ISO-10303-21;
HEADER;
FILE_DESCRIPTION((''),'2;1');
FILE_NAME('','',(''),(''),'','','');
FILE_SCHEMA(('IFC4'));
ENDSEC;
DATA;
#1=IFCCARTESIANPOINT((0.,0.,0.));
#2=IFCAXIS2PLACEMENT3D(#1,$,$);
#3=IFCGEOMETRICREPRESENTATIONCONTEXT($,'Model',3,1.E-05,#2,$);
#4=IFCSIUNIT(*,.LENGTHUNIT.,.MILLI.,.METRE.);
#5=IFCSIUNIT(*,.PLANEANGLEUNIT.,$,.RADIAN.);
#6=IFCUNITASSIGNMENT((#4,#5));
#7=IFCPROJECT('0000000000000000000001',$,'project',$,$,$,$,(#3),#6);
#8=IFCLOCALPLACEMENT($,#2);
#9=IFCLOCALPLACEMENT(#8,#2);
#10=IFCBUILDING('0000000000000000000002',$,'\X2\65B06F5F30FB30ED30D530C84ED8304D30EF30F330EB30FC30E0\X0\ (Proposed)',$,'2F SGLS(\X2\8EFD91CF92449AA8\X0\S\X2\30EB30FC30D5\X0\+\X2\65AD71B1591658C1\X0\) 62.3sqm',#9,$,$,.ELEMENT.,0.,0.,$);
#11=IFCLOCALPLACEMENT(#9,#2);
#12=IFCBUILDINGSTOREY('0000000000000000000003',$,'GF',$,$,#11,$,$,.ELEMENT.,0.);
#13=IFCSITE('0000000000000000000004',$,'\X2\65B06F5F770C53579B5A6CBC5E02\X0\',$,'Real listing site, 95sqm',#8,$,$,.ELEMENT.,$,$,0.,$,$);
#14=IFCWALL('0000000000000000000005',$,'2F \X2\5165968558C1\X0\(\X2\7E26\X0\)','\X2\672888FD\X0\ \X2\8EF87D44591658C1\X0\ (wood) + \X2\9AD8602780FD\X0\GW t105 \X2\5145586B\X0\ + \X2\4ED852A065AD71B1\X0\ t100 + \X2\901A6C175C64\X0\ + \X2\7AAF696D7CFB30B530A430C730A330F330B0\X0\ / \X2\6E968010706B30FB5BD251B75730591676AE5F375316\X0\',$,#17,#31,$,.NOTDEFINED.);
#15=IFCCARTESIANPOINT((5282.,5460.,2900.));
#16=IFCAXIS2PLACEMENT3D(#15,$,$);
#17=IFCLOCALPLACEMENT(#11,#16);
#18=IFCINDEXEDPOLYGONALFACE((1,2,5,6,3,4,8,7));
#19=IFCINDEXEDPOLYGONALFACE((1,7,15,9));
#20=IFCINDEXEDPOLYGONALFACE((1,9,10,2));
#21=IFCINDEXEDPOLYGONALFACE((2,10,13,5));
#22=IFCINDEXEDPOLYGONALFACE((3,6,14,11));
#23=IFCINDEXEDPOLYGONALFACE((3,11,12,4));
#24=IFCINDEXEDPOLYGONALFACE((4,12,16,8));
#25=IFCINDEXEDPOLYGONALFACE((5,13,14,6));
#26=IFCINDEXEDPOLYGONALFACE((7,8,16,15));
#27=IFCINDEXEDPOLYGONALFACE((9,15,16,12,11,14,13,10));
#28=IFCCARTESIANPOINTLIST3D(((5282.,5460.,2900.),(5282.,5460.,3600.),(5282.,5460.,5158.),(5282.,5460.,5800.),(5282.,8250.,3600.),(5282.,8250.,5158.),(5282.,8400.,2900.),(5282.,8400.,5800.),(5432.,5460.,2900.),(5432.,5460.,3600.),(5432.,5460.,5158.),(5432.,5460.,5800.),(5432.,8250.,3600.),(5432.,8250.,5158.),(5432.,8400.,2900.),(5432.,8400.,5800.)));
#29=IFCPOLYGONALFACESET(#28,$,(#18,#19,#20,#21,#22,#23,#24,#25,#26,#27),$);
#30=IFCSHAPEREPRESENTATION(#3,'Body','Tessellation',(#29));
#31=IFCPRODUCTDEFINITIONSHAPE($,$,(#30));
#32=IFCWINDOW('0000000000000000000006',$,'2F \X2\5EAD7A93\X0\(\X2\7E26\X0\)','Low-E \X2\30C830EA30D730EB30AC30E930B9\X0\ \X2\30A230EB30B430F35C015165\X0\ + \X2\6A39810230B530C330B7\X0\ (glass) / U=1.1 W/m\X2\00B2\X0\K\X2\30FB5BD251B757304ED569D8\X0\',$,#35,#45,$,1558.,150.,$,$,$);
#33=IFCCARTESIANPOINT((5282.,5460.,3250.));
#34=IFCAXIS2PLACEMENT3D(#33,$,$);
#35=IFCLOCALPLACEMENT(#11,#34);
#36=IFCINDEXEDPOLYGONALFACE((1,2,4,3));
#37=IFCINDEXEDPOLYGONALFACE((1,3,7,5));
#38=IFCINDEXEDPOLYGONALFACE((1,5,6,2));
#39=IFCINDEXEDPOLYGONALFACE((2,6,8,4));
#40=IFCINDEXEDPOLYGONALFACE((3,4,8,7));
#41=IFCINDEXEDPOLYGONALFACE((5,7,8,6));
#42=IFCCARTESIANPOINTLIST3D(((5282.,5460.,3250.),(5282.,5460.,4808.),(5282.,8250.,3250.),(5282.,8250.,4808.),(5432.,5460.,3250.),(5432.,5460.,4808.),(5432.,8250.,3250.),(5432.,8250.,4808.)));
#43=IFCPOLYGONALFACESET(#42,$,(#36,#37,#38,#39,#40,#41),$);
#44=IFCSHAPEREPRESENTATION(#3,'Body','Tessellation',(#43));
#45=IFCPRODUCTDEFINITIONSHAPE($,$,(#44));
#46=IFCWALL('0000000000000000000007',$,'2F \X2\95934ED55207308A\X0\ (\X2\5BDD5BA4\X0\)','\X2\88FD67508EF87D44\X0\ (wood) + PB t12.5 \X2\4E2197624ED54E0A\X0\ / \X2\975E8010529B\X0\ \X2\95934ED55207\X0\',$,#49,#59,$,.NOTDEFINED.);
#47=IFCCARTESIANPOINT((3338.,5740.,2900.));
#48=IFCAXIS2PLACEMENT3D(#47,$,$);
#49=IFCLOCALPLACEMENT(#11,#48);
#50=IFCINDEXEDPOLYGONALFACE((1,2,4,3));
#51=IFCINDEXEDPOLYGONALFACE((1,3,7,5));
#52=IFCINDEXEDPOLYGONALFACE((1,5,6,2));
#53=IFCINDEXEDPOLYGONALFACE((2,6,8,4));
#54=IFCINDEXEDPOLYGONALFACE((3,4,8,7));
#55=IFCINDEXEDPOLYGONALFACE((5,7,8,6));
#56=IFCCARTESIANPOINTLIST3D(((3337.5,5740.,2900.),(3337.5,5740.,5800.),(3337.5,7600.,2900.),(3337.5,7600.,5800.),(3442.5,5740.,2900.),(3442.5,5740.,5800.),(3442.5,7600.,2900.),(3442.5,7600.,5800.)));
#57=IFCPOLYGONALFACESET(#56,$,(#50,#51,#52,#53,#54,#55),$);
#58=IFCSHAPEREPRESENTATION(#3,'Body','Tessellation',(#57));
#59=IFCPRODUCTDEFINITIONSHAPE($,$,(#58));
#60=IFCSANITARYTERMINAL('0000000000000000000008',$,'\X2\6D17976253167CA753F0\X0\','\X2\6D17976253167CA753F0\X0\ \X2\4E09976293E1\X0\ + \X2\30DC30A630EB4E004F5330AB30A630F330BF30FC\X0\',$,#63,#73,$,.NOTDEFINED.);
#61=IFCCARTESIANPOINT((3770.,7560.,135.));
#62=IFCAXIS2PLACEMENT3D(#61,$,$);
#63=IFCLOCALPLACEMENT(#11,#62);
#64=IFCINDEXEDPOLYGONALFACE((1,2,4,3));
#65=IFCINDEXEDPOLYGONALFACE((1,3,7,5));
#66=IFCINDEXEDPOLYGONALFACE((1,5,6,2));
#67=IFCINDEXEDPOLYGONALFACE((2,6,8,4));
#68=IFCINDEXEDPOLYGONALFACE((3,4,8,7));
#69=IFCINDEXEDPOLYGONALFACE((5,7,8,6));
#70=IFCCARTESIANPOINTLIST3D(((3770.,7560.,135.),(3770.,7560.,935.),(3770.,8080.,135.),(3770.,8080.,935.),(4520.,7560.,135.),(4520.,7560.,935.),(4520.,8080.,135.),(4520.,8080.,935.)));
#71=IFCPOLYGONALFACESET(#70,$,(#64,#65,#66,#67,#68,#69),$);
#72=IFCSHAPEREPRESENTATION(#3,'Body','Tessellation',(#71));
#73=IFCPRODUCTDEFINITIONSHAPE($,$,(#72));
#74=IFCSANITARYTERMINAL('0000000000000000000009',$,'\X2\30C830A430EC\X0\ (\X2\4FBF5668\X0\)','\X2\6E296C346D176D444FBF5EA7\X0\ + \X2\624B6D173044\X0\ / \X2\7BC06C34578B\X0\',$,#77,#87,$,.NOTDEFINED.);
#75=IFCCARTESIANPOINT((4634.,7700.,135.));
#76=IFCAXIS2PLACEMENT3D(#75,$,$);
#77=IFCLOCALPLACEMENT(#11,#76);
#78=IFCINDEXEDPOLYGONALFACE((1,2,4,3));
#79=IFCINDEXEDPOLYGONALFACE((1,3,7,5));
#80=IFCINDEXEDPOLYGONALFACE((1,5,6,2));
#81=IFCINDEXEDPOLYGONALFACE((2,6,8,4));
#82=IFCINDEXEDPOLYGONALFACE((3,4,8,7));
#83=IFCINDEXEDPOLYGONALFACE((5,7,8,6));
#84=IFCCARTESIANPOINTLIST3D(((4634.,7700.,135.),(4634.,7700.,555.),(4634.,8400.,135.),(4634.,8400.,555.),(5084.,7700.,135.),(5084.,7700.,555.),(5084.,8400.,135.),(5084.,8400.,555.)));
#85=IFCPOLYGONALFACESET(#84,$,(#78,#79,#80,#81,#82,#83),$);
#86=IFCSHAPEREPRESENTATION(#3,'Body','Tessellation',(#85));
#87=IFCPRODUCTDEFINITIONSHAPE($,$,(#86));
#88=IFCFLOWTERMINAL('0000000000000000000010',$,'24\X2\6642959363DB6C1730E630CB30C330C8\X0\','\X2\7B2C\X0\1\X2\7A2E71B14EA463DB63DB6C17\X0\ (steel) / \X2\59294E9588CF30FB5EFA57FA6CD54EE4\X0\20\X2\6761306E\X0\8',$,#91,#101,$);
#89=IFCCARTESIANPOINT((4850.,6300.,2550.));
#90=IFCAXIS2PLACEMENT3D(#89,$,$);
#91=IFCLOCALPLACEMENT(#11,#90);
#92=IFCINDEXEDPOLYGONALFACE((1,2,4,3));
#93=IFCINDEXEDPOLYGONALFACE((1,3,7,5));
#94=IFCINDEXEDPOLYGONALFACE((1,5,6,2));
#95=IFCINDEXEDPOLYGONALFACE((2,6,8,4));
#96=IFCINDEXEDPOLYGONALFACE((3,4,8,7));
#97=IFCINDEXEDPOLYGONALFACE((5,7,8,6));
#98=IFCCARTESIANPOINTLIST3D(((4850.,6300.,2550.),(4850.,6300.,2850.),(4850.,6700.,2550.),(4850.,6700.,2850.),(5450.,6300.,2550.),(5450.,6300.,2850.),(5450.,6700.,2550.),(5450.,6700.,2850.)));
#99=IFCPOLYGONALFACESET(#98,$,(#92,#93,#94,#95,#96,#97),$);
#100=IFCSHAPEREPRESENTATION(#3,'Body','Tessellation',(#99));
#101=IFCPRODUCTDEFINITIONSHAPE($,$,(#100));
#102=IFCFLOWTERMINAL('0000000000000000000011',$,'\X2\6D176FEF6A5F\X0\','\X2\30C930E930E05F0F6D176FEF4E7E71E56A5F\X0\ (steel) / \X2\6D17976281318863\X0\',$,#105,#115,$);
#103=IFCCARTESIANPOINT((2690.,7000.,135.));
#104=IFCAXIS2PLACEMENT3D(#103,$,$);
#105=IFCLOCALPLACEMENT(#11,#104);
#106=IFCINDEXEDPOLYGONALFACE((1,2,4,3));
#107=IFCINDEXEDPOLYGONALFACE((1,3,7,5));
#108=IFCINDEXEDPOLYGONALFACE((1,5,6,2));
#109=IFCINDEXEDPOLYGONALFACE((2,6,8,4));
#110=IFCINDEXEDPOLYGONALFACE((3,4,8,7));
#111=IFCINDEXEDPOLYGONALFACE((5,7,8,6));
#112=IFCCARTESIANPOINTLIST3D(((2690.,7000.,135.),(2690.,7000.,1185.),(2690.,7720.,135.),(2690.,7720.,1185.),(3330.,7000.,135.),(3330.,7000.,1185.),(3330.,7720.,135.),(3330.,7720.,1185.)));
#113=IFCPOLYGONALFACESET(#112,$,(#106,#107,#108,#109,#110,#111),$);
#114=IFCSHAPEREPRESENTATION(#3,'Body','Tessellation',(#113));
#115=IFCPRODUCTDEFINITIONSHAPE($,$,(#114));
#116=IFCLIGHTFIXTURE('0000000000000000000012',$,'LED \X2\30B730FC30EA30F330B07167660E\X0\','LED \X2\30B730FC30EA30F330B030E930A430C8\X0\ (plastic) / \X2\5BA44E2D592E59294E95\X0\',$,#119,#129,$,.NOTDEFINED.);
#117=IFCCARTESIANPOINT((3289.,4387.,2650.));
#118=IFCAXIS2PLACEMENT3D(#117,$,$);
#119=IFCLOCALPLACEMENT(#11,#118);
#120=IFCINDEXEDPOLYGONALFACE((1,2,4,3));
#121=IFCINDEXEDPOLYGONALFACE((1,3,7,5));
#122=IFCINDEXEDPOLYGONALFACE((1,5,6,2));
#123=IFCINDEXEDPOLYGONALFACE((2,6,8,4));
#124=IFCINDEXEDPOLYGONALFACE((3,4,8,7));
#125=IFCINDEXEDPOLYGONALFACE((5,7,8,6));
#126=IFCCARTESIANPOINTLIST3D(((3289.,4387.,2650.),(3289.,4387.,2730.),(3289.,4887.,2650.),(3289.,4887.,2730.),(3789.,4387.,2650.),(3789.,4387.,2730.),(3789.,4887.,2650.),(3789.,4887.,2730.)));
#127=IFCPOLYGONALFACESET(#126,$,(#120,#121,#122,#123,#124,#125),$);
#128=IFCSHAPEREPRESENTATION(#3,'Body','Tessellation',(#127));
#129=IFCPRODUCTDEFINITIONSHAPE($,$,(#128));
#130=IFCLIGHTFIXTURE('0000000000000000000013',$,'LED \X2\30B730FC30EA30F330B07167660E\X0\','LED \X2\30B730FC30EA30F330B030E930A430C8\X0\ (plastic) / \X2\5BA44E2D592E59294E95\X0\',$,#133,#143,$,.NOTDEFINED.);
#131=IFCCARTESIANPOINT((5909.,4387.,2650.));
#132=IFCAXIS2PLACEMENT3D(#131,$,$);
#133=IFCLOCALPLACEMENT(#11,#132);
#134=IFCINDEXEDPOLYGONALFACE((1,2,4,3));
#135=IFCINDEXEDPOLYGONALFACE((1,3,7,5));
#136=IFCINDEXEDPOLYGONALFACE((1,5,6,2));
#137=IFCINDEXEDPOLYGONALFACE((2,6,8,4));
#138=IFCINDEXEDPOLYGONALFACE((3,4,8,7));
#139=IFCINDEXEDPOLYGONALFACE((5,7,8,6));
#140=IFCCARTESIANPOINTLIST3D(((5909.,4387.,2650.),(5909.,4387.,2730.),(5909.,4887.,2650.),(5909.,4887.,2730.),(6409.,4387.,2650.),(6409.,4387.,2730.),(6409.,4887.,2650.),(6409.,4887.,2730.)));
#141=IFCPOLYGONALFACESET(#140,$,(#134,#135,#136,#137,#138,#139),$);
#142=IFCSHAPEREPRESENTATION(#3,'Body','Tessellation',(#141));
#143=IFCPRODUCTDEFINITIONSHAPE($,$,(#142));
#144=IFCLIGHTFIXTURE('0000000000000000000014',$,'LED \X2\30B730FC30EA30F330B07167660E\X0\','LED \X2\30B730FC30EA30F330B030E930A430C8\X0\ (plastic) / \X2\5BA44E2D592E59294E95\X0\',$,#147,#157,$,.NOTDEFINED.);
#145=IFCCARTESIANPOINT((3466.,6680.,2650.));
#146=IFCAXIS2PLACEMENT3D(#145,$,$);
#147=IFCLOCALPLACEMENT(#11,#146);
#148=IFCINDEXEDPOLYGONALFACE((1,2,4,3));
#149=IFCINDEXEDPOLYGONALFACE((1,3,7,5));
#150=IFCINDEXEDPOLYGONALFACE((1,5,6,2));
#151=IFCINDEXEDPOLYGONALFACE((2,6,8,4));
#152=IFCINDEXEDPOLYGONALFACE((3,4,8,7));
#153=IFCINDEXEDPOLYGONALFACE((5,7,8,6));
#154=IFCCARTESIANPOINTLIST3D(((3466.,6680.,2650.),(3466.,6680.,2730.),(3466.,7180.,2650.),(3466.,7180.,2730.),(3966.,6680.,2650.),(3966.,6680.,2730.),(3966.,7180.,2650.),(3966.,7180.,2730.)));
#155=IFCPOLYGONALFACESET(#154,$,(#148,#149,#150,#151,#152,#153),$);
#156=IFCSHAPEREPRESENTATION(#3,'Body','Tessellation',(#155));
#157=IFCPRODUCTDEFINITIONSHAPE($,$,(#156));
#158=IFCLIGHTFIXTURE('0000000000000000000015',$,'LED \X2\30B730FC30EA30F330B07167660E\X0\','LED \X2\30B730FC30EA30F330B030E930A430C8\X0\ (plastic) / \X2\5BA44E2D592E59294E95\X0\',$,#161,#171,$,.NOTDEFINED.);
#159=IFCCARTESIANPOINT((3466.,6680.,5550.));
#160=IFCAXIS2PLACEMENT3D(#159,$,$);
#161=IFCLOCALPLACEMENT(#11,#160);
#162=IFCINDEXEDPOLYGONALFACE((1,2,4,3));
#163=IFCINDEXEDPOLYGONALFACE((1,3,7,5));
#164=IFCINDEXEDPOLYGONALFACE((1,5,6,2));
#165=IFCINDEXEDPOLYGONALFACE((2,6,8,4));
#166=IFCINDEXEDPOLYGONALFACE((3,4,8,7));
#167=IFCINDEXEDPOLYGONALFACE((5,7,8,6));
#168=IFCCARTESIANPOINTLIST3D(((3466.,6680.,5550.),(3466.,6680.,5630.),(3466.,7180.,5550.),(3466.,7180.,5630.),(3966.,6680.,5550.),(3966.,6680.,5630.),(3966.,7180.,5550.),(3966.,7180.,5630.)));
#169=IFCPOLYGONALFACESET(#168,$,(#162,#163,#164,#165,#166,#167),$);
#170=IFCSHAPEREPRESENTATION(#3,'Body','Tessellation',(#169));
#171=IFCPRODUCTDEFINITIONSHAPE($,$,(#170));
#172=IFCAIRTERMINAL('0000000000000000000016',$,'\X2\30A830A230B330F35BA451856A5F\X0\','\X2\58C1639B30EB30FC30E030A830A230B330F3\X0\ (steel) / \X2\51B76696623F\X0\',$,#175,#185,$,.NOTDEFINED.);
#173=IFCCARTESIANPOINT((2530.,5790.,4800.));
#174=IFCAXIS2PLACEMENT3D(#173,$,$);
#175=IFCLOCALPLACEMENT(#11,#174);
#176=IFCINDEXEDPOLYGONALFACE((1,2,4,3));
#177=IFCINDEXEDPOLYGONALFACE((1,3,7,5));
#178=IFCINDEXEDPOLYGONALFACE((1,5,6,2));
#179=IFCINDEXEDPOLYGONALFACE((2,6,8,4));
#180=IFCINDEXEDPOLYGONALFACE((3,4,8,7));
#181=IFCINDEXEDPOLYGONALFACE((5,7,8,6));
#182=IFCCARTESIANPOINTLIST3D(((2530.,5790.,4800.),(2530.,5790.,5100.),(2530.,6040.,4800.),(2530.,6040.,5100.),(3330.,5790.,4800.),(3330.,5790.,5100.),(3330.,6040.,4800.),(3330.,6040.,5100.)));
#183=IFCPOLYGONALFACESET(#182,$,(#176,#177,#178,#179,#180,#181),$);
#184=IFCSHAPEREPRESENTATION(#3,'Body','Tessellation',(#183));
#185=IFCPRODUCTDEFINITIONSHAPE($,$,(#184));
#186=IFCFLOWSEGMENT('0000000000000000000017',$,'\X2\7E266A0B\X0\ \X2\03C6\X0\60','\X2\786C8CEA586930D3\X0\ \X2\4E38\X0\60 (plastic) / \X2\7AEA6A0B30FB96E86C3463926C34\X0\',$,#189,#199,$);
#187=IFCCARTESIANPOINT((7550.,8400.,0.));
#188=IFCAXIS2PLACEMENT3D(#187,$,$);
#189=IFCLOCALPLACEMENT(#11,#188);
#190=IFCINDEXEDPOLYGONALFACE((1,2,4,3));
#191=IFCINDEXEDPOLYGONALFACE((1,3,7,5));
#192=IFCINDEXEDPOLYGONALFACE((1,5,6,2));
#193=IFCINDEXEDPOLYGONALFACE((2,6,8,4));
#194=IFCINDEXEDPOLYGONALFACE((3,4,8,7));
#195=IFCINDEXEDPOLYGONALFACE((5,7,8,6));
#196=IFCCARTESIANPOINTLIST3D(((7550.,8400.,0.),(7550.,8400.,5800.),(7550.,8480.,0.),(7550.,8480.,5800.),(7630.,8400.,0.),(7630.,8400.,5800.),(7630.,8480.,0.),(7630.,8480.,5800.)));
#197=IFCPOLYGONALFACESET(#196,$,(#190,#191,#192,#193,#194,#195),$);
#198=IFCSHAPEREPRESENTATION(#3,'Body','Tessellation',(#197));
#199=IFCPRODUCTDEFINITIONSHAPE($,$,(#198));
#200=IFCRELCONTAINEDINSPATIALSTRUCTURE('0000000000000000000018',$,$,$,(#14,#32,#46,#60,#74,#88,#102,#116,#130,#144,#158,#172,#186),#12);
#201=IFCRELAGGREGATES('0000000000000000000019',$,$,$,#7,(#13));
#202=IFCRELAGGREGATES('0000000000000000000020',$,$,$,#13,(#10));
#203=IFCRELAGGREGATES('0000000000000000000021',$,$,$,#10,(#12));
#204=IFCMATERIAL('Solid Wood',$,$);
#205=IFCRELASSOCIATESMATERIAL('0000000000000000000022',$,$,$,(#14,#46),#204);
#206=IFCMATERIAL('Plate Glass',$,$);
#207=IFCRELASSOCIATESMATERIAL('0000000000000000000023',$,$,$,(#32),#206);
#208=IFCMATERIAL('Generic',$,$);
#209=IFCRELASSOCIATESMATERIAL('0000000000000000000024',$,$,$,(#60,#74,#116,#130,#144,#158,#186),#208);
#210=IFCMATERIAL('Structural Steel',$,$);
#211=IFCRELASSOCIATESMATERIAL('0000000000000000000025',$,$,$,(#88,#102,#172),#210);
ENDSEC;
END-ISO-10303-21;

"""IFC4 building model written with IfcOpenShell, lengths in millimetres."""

from ifc_helpers import new_model, si_unit, frame, frame_2d, origin, place, context, project, spatial, rectangle, extrude, material, element, fill, save


model = new_model("IFC4")

# Units and contexts
model_context = context("Model", 3, precision=1e-05, world=origin())
ifc_project = project(units=[si_unit("LENGTHUNIT", "METRE", prefix="MILLI"), si_unit("PLANEANGLEUNIT", "RADIAN")], contexts=[model_context])

# Site, building, storey
site_placement = place(None, origin())
site = spatial("IfcSite", under=ifc_project, at=site_placement, Name="新潟県南魚沼市", ObjectType="Real listing site, 95sqm", CompositionType="ELEMENT", RefElevation=0.0)
building_placement = place(site_placement, origin())
building = spatial("IfcBuilding", under=site, at=building_placement, Name="新潟・ロフト付きワンルーム (Proposed)", ObjectType="2F SGLS(軽量鉄骨Sルーフ+断熱外壁) 62.3sqm", CompositionType="ELEMENT", ElevationOfRefHeight=0.0, ElevationOfTerrain=0.0)
storey_placement = place(building_placement, origin())
storey = spatial("IfcBuildingStorey", under=building, at=storey_placement, Name="GF", CompositionType="ELEMENT", Elevation=0.0)

# Shared definitions
ifc_material_1 = material(Name="Solid Wood")

# Shared definitions
ifc_material_2 = material(Name="Plate Glass")

# Wall, opening, window
wall_1_placement = place(storey_placement, frame((5282.0, 5460.0, 2900.0)))
wall_1 = element("IfcWall", 1, at=wall_1_placement, inside=storey, material=ifc_material_1, Name="2F 入隅壁(縦)", Description="木製 軸組外壁 (wood) + 高性能GW t105 充填 + 付加断熱 t100 + 通気層 + 窯業系サイディング / 準耐火・寒冷地外皮強化", PredefinedType="NOTDEFINED", context=model_context, shape_type="SweptSolid", body=[
    extrude(rectangle(XDim=150.0, YDim=2940.0, at=frame_2d((75.0, 1470.0))), frame((5282.0, 5460.0, 2900.0)), (0.0, 0.0, 1.0), 2900.0),
])
opening_1_placement = place(storey_placement, frame((5282.0, 5460.0, 3250.0)))
opening_1 = element("IfcOpeningElement", 2, at=opening_1_placement, cuts=wall_1, PredefinedType="NOTDEFINED", context=model_context, shape_type="SweptSolid", body=[
    extrude(rectangle(XDim=150.0, YDim=2790.0, at=frame_2d((75.0, 1395.0))), frame((5282.0, 5460.0, 3250.0)), (0.0, 0.0, 1.0), 1558.0),
])
window_1_placement = place(storey_placement, frame((5282.0, 5460.0, 3250.0)))
window_1 = element("IfcWindow", 3, at=window_1_placement, inside=storey, material=ifc_material_2, Name="2F 庭窓(縦)", Description="Low-E トリプルガラス アルゴン封入 + 樹脂サッシ (glass) / U=1.1 W/m²K・寒冷地仕様", OverallHeight=1558.0, OverallWidth=150.0, context=model_context, shape_type="SweptSolid", body=[
    extrude(rectangle(XDim=150.0, YDim=2790.0, at=frame_2d((75.0, 1395.0))), frame((5282.0, 5460.0, 3250.0)), (0.0, 0.0, 1.0), 1558.0),
])
fill(opening_1, window_1)

# Wall
wall_2_placement = place(storey_placement, frame((3338.0, 5740.0, 2900.0)))
element("IfcWall", 4, at=wall_2_placement, inside=storey, material=ifc_material_1, Name="2F 間仕切り (寝室)", Description="製材軸組 (wood) + PB t12.5 両面仕上 / 非耐力 間仕切", PredefinedType="NOTDEFINED", context=model_context, shape_type="SweptSolid", body=[
    extrude(rectangle(XDim=105.0, YDim=1860.0, at=frame_2d((52.0, 930.0))), frame((3338.0, 5740.0, 2900.0)), (0.0, 0.0, 1.0), 2900.0),
])

# Sanitary terminals
ifc_material_3 = material(Name="Generic")
sanitary_terminal_1_placement = place(storey_placement, frame((3770.0, 7560.0, 135.0)))
element("IfcSanitaryTerminal", 5, at=sanitary_terminal_1_placement, inside=storey, material=ifc_material_3, Name="洗面化粧台", Description="洗面化粧台 三面鏡 + ボウル一体カウンター", PredefinedType="NOTDEFINED", context=model_context, shape_type="SweptSolid", body=[
    extrude(rectangle(XDim=750.0, YDim=520.0, at=frame_2d((375.0, 260.0))), frame((3770.0, 7560.0, 135.0)), (0.0, 0.0, 1.0), 800.0),
])
sanitary_terminal_2_placement = place(storey_placement, frame((4634.0, 7700.0, 135.0)))
element("IfcSanitaryTerminal", 6, at=sanitary_terminal_2_placement, inside=storey, material=ifc_material_3, Name="トイレ (便器)", Description="温水洗浄便座 + 手洗い / 節水型", PredefinedType="NOTDEFINED", context=model_context, shape_type="SweptSolid", body=[
    extrude(rectangle(XDim=450.0, YDim=700.0, at=frame_2d((225.0, 350.0))), frame((4634.0, 7700.0, 135.0)), (0.0, 0.0, 1.0), 420.0),
])

# Flow terminals
ifc_material_4 = material(Name="Structural Steel")
flow_terminal_1_placement = place(storey_placement, frame((4850.0, 6300.0, 2550.0)))
element("IfcFlowTerminal", 7, at=flow_terminal_1_placement, inside=storey, material=ifc_material_4, Name="24時間換気ユニット", Description="第1種熱交換換気 (steel) / 天井裏・建基法令20条の8", context=model_context, shape_type="SweptSolid", body=[
    extrude(rectangle(XDim=600.0, YDim=400.0, at=frame_2d((300.0, 200.0))), frame((4850.0, 6300.0, 2550.0)), (0.0, 0.0, 1.0), 300.0),
])
flow_terminal_2_placement = place(storey_placement, frame((2690.0, 7000.0, 135.0)))
element("IfcFlowTerminal", 8, at=flow_terminal_2_placement, inside=storey, material=ifc_material_4, Name="洗濯機", Description="ドラム式洗濯乾燥機 (steel) / 洗面脱衣", context=model_context, shape_type="SweptSolid", body=[
    extrude(rectangle(XDim=640.0, YDim=720.0, at=frame_2d((320.0, 360.0))), frame((2690.0, 7000.0, 135.0)), (0.0, 0.0, 1.0), 1050.0),
])

# Light fixtures
light_fixture_1_placement = place(storey_placement, frame((3289.0, 4387.0, 2650.0)))
element("IfcLightFixture", 9, at=light_fixture_1_placement, inside=storey, material=ifc_material_3, Name="LED シーリング照明", Description="LED シーリングライト (plastic) / 室中央天井", PredefinedType="NOTDEFINED", context=model_context, shape_type="SweptSolid", body=[
    extrude(rectangle(XDim=500.0, YDim=500.0, at=frame_2d((250.0, 250.0))), frame((3289.0, 4387.0, 2650.0)), (0.0, 0.0, 1.0), 80.0),
])
light_fixture_2_placement = place(storey_placement, frame((5909.0, 4387.0, 2650.0)))
element("IfcLightFixture", 10, at=light_fixture_2_placement, inside=storey, material=ifc_material_3, Name="LED シーリング照明", Description="LED シーリングライト (plastic) / 室中央天井", PredefinedType="NOTDEFINED", context=model_context, shape_type="SweptSolid", body=[
    extrude(rectangle(XDim=500.0, YDim=500.0, at=frame_2d((250.0, 250.0))), frame((5909.0, 4387.0, 2650.0)), (0.0, 0.0, 1.0), 80.0),
])
light_fixture_3_placement = place(storey_placement, frame((3466.0, 6680.0, 2650.0)))
element("IfcLightFixture", 11, at=light_fixture_3_placement, inside=storey, material=ifc_material_3, Name="LED シーリング照明", Description="LED シーリングライト (plastic) / 室中央天井", PredefinedType="NOTDEFINED", context=model_context, shape_type="SweptSolid", body=[
    extrude(rectangle(XDim=500.0, YDim=500.0, at=frame_2d((250.0, 250.0))), frame((3466.0, 6680.0, 2650.0)), (0.0, 0.0, 1.0), 80.0),
])
light_fixture_4_placement = place(storey_placement, frame((3466.0, 6680.0, 5550.0)))
element("IfcLightFixture", 12, at=light_fixture_4_placement, inside=storey, material=ifc_material_3, Name="LED シーリング照明", Description="LED シーリングライト (plastic) / 室中央天井", PredefinedType="NOTDEFINED", context=model_context, shape_type="SweptSolid", body=[
    extrude(rectangle(XDim=500.0, YDim=500.0, at=frame_2d((250.0, 250.0))), frame((3466.0, 6680.0, 5550.0)), (0.0, 0.0, 1.0), 80.0),
])

# Air terminal
air_terminal_placement = place(storey_placement, frame((2530.0, 5790.0, 4800.0)))
element("IfcAirTerminal", 13, at=air_terminal_placement, inside=storey, material=ifc_material_4, Name="エアコン室内機", Description="壁掛ルームエアコン (steel) / 冷暖房", PredefinedType="NOTDEFINED", context=model_context, shape_type="SweptSolid", body=[
    extrude(rectangle(XDim=800.0, YDim=250.0, at=frame_2d((400.0, 125.0))), frame((2530.0, 5790.0, 4800.0)), (0.0, 0.0, 1.0), 300.0),
])

# Flow segment
flow_segment_placement = place(storey_placement, frame((7550.0, 8400.0, 0.0)))
element("IfcFlowSegment", 14, at=flow_segment_placement, inside=storey, material=ifc_material_3, Name="縦樋 φ60", Description="硬質塩ビ 丸60 (plastic) / 竪樋・雨水排水", context=model_context, shape_type="SweptSolid", body=[
    extrude(rectangle(XDim=80.0, YDim=80.0, at=frame_2d((40.0, 40.0))), frame((7550.0, 8400.0, 0.0)), (0.0, 0.0, 1.0), 5800.0),
])

save(model, "model.ifc")
